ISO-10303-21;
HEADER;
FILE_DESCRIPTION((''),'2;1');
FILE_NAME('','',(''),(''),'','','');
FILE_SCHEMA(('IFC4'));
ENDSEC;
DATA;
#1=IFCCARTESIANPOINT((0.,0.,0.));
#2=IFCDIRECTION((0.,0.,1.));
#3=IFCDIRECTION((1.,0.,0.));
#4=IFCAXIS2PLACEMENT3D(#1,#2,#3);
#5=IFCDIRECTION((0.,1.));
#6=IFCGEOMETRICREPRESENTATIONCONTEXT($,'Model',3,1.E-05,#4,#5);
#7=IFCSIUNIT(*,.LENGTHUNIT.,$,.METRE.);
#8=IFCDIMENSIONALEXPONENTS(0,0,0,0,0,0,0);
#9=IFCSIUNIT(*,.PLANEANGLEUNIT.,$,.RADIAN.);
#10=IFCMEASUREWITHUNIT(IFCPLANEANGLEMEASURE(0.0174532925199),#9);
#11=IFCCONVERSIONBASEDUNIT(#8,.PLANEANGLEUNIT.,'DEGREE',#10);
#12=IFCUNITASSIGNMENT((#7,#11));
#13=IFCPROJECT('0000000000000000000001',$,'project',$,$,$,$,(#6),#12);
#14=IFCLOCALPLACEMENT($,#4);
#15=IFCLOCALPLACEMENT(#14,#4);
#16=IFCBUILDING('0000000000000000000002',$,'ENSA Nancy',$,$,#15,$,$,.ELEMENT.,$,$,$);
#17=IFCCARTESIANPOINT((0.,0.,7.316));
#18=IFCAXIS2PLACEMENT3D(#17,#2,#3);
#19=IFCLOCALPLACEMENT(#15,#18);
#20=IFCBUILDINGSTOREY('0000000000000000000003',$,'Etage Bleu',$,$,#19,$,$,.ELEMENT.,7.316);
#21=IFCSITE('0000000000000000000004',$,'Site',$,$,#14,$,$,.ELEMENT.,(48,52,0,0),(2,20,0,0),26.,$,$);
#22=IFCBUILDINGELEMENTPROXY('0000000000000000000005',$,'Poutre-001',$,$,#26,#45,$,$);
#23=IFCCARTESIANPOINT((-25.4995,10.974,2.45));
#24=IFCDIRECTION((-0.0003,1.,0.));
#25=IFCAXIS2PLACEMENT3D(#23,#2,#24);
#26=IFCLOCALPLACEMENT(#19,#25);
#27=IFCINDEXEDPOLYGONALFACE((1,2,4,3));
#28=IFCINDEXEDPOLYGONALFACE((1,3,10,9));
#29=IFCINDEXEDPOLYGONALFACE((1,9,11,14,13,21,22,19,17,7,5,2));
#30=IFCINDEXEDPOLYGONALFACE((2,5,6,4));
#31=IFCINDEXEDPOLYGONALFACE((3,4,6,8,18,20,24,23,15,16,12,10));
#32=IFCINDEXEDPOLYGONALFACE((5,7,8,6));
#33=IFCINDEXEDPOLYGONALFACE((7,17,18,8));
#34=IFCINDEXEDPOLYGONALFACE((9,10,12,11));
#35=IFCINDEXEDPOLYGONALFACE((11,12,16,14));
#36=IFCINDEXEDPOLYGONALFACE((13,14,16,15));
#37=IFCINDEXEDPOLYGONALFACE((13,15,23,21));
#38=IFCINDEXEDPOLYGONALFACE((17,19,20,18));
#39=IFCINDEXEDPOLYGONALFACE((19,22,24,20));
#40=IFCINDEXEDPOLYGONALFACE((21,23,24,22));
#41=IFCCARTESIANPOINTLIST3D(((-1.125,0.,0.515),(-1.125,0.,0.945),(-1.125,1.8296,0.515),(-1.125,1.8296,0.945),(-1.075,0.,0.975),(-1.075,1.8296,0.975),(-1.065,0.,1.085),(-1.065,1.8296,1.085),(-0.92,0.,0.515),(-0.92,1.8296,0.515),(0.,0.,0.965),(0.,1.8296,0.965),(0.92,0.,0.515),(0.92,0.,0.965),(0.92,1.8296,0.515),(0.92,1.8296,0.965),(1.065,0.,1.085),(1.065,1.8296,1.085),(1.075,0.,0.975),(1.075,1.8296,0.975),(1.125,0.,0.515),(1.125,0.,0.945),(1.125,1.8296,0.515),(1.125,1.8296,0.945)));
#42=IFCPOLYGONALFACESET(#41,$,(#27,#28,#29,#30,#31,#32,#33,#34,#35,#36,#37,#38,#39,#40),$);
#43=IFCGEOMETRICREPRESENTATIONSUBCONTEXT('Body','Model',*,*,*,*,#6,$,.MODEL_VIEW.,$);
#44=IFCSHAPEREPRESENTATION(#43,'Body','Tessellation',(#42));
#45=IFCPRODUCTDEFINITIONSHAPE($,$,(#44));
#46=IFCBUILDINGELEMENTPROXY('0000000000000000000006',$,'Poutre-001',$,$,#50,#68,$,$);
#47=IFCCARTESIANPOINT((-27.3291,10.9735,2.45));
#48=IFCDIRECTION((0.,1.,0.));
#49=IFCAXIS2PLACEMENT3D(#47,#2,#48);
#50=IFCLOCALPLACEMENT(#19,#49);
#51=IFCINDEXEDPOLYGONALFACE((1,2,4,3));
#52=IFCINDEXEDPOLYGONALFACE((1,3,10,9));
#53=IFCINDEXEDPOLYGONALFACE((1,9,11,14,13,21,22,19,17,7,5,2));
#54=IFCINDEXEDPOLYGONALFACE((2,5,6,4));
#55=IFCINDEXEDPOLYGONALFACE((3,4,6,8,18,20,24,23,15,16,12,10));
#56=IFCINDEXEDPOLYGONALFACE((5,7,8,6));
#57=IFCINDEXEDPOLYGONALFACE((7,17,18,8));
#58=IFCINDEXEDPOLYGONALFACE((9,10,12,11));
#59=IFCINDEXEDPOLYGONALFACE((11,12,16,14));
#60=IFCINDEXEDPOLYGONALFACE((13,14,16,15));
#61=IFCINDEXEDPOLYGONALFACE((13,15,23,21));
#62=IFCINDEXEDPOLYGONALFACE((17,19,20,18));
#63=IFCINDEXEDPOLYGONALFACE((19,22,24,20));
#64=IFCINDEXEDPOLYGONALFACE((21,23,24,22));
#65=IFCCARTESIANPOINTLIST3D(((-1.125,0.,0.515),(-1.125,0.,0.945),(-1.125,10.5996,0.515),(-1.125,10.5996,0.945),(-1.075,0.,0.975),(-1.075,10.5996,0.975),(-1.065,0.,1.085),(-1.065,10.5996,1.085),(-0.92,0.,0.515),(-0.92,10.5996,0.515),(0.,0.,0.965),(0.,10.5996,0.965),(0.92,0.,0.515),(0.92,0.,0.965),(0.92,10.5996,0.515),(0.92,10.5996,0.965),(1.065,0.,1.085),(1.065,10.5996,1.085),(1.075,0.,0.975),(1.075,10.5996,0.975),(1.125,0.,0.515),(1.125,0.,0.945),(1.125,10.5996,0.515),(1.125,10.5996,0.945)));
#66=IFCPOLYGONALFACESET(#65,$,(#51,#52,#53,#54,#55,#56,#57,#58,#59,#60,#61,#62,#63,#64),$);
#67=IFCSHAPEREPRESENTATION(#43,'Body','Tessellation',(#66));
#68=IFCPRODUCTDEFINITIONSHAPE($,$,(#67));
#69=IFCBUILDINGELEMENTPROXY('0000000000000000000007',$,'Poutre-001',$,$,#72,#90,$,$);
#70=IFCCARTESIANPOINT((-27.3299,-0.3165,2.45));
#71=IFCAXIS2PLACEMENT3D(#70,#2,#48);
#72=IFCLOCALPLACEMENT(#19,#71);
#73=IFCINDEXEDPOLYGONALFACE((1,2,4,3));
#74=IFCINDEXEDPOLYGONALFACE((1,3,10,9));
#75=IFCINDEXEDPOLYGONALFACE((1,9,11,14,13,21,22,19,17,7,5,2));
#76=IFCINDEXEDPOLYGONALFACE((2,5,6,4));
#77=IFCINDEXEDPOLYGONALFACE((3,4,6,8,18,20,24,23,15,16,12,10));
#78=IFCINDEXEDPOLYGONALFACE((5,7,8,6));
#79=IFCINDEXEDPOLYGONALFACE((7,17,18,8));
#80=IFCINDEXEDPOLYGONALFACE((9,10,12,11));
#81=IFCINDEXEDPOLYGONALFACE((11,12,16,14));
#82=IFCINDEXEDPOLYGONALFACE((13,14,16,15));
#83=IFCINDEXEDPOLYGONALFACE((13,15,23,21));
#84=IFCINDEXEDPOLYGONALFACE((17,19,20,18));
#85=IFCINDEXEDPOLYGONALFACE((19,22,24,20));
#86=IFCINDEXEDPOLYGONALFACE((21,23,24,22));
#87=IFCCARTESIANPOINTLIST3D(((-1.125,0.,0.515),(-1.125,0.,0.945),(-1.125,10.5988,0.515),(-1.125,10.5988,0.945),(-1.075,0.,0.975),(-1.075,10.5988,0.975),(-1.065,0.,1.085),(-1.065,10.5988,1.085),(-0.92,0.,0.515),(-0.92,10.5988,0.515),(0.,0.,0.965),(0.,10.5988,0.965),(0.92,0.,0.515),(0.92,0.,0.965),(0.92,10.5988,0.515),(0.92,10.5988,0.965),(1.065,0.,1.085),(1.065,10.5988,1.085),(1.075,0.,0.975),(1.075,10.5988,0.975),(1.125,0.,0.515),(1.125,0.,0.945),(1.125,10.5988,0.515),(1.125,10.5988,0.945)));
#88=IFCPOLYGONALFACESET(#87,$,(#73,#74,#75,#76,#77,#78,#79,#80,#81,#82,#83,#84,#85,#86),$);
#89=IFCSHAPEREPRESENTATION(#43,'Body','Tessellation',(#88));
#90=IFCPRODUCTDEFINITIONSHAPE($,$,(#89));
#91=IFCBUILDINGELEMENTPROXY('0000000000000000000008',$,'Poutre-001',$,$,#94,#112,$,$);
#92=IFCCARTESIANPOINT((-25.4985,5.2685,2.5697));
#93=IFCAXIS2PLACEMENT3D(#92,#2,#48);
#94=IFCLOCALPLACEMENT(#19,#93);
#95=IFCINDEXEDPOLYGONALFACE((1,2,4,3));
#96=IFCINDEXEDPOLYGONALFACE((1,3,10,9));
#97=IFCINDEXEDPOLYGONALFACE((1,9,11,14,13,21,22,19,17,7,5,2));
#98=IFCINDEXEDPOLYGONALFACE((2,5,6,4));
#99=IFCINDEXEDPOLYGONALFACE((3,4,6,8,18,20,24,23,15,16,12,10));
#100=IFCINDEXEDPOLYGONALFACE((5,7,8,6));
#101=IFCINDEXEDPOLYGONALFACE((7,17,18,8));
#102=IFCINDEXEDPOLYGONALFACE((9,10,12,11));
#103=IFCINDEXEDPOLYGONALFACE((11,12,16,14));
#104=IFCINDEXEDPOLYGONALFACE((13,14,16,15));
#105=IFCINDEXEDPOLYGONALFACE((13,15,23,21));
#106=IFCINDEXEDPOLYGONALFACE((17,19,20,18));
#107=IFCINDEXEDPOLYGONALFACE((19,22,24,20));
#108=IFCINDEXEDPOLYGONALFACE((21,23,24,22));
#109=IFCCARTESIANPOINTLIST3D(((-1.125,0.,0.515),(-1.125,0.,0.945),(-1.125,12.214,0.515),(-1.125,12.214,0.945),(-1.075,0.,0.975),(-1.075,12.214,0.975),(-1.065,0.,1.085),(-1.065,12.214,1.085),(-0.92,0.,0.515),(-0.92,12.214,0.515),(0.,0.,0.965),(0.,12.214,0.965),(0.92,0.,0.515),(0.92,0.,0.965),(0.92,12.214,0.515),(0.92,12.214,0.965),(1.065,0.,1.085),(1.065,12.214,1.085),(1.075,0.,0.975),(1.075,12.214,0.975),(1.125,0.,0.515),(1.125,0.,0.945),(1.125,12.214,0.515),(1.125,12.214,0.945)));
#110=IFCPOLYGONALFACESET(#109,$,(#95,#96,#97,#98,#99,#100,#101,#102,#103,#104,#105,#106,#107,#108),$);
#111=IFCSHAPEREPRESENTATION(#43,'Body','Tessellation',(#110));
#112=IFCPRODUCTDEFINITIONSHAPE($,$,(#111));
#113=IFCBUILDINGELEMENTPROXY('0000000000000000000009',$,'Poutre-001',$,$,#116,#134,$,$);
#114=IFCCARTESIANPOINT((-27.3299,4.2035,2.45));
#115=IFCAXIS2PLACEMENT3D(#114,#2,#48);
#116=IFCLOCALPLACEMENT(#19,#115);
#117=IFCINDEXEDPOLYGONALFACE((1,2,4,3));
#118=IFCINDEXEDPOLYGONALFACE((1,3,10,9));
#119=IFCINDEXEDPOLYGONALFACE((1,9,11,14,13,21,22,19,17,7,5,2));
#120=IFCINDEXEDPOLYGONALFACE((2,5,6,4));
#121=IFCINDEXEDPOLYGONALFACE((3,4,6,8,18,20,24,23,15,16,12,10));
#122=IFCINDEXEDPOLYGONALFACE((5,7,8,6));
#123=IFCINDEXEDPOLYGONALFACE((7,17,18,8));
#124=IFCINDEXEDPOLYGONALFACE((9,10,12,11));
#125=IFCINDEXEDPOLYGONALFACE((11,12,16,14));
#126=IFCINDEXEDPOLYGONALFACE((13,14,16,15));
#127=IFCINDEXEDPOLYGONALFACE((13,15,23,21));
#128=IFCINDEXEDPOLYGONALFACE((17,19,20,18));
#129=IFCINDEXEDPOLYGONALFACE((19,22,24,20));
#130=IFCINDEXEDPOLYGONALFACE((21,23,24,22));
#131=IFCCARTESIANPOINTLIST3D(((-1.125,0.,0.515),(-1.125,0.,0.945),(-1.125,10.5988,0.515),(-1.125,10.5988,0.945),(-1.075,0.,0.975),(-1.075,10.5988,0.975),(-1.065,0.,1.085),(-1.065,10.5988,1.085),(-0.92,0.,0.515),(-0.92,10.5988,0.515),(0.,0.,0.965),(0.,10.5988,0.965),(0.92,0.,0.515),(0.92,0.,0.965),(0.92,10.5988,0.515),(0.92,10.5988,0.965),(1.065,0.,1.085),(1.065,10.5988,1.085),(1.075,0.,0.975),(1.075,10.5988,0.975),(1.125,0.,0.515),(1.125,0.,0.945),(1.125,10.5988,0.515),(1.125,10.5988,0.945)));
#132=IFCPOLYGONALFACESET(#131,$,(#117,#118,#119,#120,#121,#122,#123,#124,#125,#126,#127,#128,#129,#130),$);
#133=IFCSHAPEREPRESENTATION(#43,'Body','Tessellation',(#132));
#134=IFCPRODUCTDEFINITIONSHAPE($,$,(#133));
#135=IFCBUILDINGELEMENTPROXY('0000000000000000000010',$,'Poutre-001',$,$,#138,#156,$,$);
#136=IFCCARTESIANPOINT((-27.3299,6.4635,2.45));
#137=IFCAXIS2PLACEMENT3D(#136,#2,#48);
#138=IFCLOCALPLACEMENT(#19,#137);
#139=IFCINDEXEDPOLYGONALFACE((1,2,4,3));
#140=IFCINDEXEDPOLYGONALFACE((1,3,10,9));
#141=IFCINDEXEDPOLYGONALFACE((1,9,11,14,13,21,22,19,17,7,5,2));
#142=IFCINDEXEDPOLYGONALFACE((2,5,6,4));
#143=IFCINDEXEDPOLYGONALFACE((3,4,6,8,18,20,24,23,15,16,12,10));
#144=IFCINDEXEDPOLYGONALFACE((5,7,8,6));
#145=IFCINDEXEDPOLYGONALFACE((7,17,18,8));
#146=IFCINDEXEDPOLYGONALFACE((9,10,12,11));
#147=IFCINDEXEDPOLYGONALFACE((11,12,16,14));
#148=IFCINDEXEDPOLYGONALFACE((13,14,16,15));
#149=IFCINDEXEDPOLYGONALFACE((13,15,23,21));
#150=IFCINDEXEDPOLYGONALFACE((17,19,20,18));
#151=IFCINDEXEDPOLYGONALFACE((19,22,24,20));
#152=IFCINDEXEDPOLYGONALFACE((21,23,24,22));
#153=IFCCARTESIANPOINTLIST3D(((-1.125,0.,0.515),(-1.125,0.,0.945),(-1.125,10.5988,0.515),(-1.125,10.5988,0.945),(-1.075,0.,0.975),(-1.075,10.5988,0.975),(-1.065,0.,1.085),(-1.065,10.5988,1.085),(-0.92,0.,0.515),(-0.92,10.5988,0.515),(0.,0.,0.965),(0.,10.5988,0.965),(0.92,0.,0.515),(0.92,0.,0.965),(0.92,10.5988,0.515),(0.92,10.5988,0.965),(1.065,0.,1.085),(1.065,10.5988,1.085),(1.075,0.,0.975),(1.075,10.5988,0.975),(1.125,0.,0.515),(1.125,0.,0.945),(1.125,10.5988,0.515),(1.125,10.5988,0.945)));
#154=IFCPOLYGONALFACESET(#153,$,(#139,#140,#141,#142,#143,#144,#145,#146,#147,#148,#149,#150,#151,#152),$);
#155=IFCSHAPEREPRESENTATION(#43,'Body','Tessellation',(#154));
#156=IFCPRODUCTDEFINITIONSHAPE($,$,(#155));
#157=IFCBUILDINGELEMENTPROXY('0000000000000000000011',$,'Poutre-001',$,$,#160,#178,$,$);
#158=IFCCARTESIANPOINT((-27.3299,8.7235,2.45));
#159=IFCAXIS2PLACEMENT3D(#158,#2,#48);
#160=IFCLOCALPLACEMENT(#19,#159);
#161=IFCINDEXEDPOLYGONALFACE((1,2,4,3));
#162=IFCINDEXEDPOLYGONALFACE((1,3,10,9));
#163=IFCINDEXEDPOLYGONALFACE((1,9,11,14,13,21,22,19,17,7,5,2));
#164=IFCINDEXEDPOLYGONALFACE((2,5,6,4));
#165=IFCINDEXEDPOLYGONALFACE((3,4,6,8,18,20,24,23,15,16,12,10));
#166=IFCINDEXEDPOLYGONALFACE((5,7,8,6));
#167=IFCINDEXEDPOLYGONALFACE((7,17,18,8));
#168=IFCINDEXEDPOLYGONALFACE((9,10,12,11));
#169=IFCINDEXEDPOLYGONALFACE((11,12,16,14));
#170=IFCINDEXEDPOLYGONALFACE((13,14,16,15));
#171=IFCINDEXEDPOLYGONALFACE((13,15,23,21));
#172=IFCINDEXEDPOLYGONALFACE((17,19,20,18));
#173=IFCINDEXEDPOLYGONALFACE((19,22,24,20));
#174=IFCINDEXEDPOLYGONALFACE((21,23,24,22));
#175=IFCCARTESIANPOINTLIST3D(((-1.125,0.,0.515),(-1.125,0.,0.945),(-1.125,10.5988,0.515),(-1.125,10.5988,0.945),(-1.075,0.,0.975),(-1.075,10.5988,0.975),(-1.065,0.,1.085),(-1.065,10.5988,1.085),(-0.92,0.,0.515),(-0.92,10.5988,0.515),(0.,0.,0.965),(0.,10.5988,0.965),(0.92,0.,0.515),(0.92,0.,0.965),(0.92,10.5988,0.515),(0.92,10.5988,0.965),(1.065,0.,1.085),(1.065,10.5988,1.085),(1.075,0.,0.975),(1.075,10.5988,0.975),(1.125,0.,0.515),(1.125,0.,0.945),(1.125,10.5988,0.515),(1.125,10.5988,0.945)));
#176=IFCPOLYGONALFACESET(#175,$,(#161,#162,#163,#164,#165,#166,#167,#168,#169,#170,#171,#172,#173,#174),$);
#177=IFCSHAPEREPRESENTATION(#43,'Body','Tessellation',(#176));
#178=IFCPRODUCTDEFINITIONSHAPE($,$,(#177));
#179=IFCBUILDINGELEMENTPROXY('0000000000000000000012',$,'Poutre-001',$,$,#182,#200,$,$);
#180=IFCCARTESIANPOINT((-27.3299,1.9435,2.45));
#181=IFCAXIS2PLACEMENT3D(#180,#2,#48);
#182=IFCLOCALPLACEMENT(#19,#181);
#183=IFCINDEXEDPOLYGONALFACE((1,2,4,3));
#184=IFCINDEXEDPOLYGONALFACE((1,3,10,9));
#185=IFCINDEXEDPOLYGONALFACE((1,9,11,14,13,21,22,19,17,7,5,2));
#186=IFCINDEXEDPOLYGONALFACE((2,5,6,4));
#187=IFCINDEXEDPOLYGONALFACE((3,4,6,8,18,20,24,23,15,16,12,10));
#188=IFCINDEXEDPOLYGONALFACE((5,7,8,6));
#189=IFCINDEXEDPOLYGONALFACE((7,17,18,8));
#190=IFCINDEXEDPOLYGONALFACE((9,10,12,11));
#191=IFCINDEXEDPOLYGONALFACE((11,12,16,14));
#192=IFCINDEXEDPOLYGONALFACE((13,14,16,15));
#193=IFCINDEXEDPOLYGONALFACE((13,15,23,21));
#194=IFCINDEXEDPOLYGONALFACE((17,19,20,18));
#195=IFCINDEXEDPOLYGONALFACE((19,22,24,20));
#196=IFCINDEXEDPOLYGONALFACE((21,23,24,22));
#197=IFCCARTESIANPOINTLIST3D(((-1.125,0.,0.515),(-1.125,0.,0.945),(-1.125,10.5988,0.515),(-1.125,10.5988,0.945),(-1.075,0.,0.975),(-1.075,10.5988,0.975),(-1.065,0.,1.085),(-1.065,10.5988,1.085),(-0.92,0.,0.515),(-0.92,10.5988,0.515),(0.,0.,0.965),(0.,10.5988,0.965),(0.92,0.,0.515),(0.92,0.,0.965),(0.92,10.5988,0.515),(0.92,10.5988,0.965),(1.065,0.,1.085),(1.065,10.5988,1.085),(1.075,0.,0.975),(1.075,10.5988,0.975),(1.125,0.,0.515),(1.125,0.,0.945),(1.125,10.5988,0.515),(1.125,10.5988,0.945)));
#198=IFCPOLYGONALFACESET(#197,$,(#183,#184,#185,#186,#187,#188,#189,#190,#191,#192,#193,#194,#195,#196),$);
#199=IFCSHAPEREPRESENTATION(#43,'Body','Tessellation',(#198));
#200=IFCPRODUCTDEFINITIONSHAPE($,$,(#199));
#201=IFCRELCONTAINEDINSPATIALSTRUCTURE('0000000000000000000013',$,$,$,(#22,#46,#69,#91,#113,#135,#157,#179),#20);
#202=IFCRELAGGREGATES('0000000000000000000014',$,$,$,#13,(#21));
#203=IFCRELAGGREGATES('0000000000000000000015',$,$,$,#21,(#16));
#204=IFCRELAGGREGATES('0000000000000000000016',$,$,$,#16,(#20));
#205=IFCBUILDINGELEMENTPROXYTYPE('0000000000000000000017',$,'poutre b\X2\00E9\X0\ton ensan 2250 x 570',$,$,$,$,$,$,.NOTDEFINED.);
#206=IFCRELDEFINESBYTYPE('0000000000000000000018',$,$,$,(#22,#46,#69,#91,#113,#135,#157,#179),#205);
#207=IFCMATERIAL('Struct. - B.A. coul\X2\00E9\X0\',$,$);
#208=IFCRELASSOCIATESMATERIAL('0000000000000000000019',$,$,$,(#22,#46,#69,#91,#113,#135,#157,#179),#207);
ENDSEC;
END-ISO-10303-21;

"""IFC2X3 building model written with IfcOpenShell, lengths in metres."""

from ifc_helpers import new_model, entity, si_unit, converted_unit, direction, frame, origin_with_axes, place, context, subcontext, project, spatial, polyline, outline, extrude, material, type_object, element, save


model = new_model("IFC2X3")

# Units and contexts
model_context = context("Model", 3, precision=1e-05, world=origin_with_axes(), true_north=direction((0.0, 1.0)))
body_context = subcontext(model_context, "Body", "Model", "MODEL_VIEW")
ifc_project = project(units=[si_unit("LENGTHUNIT", "METRE"), converted_unit("PLANEANGLEUNIT", "DEGREE", entity("IfcPlaneAngleMeasure", 0.0174532925199), si_unit("PLANEANGLEUNIT", "RADIAN"), dimensions=[0, 0, 0, 0, 0, 0, 0])], contexts=[model_context])

# Site, building, storey
site_placement = place(None, origin_with_axes())
site = spatial("IfcSite", under=ifc_project, at=site_placement, Name="Site", CompositionType="ELEMENT", RefLatitude=(48, 52, 0, 0), RefLongitude=(2, 20, 0, 0), RefElevation=26.0)
building_placement = place(site_placement, origin_with_axes())
building = spatial("IfcBuilding", under=site, at=building_placement, Name="ENSA Nancy", CompositionType="ELEMENT")
storey_placement = place(building_placement, frame((0.0, 0.0, 7.316), z_axis=(0.0, 0.0, 1.0), x_axis=(1.0, 0.0, 0.0)))
storey = spatial("IfcBuildingStorey", under=building, at=storey_placement, Name="Etage Bleu", CompositionType="ELEMENT", Elevation=7.316)

# Building element proxies
ifc_material_1 = material(Name="Struct. - B.A. coulé")
building_element_proxy_type_1 = type_object("IfcBuildingElementProxyType", Name="poutre béton ensan 2250 x 570", PredefinedType="NOTDEFINED")
proxy_1_placement = place(storey_placement, frame((-25.4995, 10.974, 2.45), z_axis=(0.0, 0.0, 1.0), x_axis=(-0.0003, 1.0, 0.0)))
element("IfcBuildingElementProxy", 1, at=proxy_1_placement, inside=storey, type_object=building_element_proxy_type_1, material=ifc_material_1, Name="Poutre-001", context=body_context, shape_type="SweptSolid", body=[
    extrude(outline(polyline([(-1.065, 1.085), (-1.075, 0.975), (-1.125, 0.945), (-1.125, 0.515), (-0.92, 0.515), (0.0, 0.965), (0.92, 0.965), (0.92, 0.515), (1.125, 0.515), (1.125, 0.945), (1.075, 0.975), (1.065, 1.085), (-1.065, 1.085)])), frame((0.0, 1.8296, 0.0), z_axis=(0.0, -1.0, 0.0), x_axis=(1.0, 0.0, 0.0)), (0.0, 0.0, 1.0), 1.8296),
])
proxy_2_placement = place(storey_placement, frame((-27.3291, 10.9735, 2.45), z_axis=(0.0, 0.0, 1.0), x_axis=(0.0, 1.0, 0.0)))
element("IfcBuildingElementProxy", 2, at=proxy_2_placement, inside=storey, type_object=building_element_proxy_type_1, material=ifc_material_1, Name="Poutre-001", context=body_context, shape_type="SweptSolid", body=[
    extrude(outline(polyline([(-1.065, 1.085), (-1.075, 0.975), (-1.125, 0.945), (-1.125, 0.515), (-0.92, 0.515), (0.0, 0.965), (0.92, 0.965), (0.92, 0.515), (1.125, 0.515), (1.125, 0.945), (1.075, 0.975), (1.065, 1.085), (-1.065, 1.085)])), frame((0.0, 10.5996, 0.0), z_axis=(0.0, -1.0, 0.0), x_axis=(1.0, 0.0, 0.0)), (0.0, 0.0, 1.0), 10.5996),
])
proxy_3_placement = place(storey_placement, frame((-27.3299, -0.3165, 2.45), z_axis=(0.0, 0.0, 1.0), x_axis=(0.0, 1.0, 0.0)))
element("IfcBuildingElementProxy", 3, at=proxy_3_placement, inside=storey, type_object=building_element_proxy_type_1, material=ifc_material_1, Name="Poutre-001", context=body_context, shape_type="SweptSolid", body=[
    extrude(outline(polyline([(-1.065, 1.085), (-1.075, 0.975), (-1.125, 0.945), (-1.125, 0.515), (-0.92, 0.515), (0.0, 0.965), (0.92, 0.965), (0.92, 0.515), (1.125, 0.515), (1.125, 0.945), (1.075, 0.975), (1.065, 1.085), (-1.065, 1.085)])), frame((0.0, 10.5988, 0.0), z_axis=(0.0, -1.0, 0.0), x_axis=(1.0, 0.0, 0.0)), (0.0, 0.0, 1.0), 10.5988),
])
proxy_4_placement = place(storey_placement, frame((-25.4985, 5.2685, 2.5697), z_axis=(0.0, 0.0, 1.0), x_axis=(0.0, 1.0, 0.0)))
element("IfcBuildingElementProxy", 4, at=proxy_4_placement, inside=storey, type_object=building_element_proxy_type_1, material=ifc_material_1, Name="Poutre-001", context=body_context, shape_type="SweptSolid", body=[
    extrude(outline(polyline([(-1.065, 1.085), (-1.075, 0.975), (-1.125, 0.945), (-1.125, 0.515), (-0.92, 0.515), (0.0, 0.965), (0.92, 0.965), (0.92, 0.515), (1.125, 0.515), (1.125, 0.945), (1.075, 0.975), (1.065, 1.085), (-1.065, 1.085)])), frame((0.0, 12.214, 0.0), z_axis=(0.0, -1.0, 0.0), x_axis=(1.0, 0.0, 0.0)), (0.0, 0.0, 1.0), 12.214),
])
proxy_5_placement = place(storey_placement, frame((-27.3299, 4.2035, 2.45), z_axis=(0.0, 0.0, 1.0), x_axis=(0.0, 1.0, 0.0)))
element("IfcBuildingElementProxy", 5, at=proxy_5_placement, inside=storey, type_object=building_element_proxy_type_1, material=ifc_material_1, Name="Poutre-001", context=body_context, shape_type="SweptSolid", body=[
    extrude(outline(polyline([(-1.065, 1.085), (-1.075, 0.975), (-1.125, 0.945), (-1.125, 0.515), (-0.92, 0.515), (0.0, 0.965), (0.92, 0.965), (0.92, 0.515), (1.125, 0.515), (1.125, 0.945), (1.075, 0.975), (1.065, 1.085), (-1.065, 1.085)])), frame((0.0, 10.5988, 0.0), z_axis=(0.0, -1.0, 0.0), x_axis=(1.0, 0.0, 0.0)), (0.0, 0.0, 1.0), 10.5988),
])
for number, where, z_axis, x_axis, name in (
    (6, (-27.3299, 6.4635, 2.45), (0.0, 0.0, 1.0), (0.0, 1.0, 0.0), "Poutre-001"),
    (7, (-27.3299, 8.7235, 2.45), (0.0, 0.0, 1.0), (0.0, 1.0, 0.0), "Poutre-001"),
    (8, (-27.3299, 1.9435, 2.45), (0.0, 0.0, 1.0), (0.0, 1.0, 0.0), "Poutre-001"),
):
    element("IfcBuildingElementProxy", number, at=place(storey_placement, frame(where, z_axis=z_axis, x_axis=x_axis)), inside=storey, type_object=building_element_proxy_type_1, material=ifc_material_1, Name=name, context=body_context, shape_type="SweptSolid", body=[
        extrude(outline(polyline([(-1.065, 1.085), (-1.075, 0.975), (-1.125, 0.945), (-1.125, 0.515), (-0.92, 0.515), (0.0, 0.965), (0.92, 0.965), (0.92, 0.515), (1.125, 0.515), (1.125, 0.945), (1.075, 0.975), (1.065, 1.085), (-1.065, 1.085)])), frame((0.0, 10.5988, 0.0), z_axis=(0.0, -1.0, 0.0), x_axis=(1.0, 0.0, 0.0)), (0.0, 0.0, 1.0), 10.5988),
    ])

save(model, "model.ifc")
